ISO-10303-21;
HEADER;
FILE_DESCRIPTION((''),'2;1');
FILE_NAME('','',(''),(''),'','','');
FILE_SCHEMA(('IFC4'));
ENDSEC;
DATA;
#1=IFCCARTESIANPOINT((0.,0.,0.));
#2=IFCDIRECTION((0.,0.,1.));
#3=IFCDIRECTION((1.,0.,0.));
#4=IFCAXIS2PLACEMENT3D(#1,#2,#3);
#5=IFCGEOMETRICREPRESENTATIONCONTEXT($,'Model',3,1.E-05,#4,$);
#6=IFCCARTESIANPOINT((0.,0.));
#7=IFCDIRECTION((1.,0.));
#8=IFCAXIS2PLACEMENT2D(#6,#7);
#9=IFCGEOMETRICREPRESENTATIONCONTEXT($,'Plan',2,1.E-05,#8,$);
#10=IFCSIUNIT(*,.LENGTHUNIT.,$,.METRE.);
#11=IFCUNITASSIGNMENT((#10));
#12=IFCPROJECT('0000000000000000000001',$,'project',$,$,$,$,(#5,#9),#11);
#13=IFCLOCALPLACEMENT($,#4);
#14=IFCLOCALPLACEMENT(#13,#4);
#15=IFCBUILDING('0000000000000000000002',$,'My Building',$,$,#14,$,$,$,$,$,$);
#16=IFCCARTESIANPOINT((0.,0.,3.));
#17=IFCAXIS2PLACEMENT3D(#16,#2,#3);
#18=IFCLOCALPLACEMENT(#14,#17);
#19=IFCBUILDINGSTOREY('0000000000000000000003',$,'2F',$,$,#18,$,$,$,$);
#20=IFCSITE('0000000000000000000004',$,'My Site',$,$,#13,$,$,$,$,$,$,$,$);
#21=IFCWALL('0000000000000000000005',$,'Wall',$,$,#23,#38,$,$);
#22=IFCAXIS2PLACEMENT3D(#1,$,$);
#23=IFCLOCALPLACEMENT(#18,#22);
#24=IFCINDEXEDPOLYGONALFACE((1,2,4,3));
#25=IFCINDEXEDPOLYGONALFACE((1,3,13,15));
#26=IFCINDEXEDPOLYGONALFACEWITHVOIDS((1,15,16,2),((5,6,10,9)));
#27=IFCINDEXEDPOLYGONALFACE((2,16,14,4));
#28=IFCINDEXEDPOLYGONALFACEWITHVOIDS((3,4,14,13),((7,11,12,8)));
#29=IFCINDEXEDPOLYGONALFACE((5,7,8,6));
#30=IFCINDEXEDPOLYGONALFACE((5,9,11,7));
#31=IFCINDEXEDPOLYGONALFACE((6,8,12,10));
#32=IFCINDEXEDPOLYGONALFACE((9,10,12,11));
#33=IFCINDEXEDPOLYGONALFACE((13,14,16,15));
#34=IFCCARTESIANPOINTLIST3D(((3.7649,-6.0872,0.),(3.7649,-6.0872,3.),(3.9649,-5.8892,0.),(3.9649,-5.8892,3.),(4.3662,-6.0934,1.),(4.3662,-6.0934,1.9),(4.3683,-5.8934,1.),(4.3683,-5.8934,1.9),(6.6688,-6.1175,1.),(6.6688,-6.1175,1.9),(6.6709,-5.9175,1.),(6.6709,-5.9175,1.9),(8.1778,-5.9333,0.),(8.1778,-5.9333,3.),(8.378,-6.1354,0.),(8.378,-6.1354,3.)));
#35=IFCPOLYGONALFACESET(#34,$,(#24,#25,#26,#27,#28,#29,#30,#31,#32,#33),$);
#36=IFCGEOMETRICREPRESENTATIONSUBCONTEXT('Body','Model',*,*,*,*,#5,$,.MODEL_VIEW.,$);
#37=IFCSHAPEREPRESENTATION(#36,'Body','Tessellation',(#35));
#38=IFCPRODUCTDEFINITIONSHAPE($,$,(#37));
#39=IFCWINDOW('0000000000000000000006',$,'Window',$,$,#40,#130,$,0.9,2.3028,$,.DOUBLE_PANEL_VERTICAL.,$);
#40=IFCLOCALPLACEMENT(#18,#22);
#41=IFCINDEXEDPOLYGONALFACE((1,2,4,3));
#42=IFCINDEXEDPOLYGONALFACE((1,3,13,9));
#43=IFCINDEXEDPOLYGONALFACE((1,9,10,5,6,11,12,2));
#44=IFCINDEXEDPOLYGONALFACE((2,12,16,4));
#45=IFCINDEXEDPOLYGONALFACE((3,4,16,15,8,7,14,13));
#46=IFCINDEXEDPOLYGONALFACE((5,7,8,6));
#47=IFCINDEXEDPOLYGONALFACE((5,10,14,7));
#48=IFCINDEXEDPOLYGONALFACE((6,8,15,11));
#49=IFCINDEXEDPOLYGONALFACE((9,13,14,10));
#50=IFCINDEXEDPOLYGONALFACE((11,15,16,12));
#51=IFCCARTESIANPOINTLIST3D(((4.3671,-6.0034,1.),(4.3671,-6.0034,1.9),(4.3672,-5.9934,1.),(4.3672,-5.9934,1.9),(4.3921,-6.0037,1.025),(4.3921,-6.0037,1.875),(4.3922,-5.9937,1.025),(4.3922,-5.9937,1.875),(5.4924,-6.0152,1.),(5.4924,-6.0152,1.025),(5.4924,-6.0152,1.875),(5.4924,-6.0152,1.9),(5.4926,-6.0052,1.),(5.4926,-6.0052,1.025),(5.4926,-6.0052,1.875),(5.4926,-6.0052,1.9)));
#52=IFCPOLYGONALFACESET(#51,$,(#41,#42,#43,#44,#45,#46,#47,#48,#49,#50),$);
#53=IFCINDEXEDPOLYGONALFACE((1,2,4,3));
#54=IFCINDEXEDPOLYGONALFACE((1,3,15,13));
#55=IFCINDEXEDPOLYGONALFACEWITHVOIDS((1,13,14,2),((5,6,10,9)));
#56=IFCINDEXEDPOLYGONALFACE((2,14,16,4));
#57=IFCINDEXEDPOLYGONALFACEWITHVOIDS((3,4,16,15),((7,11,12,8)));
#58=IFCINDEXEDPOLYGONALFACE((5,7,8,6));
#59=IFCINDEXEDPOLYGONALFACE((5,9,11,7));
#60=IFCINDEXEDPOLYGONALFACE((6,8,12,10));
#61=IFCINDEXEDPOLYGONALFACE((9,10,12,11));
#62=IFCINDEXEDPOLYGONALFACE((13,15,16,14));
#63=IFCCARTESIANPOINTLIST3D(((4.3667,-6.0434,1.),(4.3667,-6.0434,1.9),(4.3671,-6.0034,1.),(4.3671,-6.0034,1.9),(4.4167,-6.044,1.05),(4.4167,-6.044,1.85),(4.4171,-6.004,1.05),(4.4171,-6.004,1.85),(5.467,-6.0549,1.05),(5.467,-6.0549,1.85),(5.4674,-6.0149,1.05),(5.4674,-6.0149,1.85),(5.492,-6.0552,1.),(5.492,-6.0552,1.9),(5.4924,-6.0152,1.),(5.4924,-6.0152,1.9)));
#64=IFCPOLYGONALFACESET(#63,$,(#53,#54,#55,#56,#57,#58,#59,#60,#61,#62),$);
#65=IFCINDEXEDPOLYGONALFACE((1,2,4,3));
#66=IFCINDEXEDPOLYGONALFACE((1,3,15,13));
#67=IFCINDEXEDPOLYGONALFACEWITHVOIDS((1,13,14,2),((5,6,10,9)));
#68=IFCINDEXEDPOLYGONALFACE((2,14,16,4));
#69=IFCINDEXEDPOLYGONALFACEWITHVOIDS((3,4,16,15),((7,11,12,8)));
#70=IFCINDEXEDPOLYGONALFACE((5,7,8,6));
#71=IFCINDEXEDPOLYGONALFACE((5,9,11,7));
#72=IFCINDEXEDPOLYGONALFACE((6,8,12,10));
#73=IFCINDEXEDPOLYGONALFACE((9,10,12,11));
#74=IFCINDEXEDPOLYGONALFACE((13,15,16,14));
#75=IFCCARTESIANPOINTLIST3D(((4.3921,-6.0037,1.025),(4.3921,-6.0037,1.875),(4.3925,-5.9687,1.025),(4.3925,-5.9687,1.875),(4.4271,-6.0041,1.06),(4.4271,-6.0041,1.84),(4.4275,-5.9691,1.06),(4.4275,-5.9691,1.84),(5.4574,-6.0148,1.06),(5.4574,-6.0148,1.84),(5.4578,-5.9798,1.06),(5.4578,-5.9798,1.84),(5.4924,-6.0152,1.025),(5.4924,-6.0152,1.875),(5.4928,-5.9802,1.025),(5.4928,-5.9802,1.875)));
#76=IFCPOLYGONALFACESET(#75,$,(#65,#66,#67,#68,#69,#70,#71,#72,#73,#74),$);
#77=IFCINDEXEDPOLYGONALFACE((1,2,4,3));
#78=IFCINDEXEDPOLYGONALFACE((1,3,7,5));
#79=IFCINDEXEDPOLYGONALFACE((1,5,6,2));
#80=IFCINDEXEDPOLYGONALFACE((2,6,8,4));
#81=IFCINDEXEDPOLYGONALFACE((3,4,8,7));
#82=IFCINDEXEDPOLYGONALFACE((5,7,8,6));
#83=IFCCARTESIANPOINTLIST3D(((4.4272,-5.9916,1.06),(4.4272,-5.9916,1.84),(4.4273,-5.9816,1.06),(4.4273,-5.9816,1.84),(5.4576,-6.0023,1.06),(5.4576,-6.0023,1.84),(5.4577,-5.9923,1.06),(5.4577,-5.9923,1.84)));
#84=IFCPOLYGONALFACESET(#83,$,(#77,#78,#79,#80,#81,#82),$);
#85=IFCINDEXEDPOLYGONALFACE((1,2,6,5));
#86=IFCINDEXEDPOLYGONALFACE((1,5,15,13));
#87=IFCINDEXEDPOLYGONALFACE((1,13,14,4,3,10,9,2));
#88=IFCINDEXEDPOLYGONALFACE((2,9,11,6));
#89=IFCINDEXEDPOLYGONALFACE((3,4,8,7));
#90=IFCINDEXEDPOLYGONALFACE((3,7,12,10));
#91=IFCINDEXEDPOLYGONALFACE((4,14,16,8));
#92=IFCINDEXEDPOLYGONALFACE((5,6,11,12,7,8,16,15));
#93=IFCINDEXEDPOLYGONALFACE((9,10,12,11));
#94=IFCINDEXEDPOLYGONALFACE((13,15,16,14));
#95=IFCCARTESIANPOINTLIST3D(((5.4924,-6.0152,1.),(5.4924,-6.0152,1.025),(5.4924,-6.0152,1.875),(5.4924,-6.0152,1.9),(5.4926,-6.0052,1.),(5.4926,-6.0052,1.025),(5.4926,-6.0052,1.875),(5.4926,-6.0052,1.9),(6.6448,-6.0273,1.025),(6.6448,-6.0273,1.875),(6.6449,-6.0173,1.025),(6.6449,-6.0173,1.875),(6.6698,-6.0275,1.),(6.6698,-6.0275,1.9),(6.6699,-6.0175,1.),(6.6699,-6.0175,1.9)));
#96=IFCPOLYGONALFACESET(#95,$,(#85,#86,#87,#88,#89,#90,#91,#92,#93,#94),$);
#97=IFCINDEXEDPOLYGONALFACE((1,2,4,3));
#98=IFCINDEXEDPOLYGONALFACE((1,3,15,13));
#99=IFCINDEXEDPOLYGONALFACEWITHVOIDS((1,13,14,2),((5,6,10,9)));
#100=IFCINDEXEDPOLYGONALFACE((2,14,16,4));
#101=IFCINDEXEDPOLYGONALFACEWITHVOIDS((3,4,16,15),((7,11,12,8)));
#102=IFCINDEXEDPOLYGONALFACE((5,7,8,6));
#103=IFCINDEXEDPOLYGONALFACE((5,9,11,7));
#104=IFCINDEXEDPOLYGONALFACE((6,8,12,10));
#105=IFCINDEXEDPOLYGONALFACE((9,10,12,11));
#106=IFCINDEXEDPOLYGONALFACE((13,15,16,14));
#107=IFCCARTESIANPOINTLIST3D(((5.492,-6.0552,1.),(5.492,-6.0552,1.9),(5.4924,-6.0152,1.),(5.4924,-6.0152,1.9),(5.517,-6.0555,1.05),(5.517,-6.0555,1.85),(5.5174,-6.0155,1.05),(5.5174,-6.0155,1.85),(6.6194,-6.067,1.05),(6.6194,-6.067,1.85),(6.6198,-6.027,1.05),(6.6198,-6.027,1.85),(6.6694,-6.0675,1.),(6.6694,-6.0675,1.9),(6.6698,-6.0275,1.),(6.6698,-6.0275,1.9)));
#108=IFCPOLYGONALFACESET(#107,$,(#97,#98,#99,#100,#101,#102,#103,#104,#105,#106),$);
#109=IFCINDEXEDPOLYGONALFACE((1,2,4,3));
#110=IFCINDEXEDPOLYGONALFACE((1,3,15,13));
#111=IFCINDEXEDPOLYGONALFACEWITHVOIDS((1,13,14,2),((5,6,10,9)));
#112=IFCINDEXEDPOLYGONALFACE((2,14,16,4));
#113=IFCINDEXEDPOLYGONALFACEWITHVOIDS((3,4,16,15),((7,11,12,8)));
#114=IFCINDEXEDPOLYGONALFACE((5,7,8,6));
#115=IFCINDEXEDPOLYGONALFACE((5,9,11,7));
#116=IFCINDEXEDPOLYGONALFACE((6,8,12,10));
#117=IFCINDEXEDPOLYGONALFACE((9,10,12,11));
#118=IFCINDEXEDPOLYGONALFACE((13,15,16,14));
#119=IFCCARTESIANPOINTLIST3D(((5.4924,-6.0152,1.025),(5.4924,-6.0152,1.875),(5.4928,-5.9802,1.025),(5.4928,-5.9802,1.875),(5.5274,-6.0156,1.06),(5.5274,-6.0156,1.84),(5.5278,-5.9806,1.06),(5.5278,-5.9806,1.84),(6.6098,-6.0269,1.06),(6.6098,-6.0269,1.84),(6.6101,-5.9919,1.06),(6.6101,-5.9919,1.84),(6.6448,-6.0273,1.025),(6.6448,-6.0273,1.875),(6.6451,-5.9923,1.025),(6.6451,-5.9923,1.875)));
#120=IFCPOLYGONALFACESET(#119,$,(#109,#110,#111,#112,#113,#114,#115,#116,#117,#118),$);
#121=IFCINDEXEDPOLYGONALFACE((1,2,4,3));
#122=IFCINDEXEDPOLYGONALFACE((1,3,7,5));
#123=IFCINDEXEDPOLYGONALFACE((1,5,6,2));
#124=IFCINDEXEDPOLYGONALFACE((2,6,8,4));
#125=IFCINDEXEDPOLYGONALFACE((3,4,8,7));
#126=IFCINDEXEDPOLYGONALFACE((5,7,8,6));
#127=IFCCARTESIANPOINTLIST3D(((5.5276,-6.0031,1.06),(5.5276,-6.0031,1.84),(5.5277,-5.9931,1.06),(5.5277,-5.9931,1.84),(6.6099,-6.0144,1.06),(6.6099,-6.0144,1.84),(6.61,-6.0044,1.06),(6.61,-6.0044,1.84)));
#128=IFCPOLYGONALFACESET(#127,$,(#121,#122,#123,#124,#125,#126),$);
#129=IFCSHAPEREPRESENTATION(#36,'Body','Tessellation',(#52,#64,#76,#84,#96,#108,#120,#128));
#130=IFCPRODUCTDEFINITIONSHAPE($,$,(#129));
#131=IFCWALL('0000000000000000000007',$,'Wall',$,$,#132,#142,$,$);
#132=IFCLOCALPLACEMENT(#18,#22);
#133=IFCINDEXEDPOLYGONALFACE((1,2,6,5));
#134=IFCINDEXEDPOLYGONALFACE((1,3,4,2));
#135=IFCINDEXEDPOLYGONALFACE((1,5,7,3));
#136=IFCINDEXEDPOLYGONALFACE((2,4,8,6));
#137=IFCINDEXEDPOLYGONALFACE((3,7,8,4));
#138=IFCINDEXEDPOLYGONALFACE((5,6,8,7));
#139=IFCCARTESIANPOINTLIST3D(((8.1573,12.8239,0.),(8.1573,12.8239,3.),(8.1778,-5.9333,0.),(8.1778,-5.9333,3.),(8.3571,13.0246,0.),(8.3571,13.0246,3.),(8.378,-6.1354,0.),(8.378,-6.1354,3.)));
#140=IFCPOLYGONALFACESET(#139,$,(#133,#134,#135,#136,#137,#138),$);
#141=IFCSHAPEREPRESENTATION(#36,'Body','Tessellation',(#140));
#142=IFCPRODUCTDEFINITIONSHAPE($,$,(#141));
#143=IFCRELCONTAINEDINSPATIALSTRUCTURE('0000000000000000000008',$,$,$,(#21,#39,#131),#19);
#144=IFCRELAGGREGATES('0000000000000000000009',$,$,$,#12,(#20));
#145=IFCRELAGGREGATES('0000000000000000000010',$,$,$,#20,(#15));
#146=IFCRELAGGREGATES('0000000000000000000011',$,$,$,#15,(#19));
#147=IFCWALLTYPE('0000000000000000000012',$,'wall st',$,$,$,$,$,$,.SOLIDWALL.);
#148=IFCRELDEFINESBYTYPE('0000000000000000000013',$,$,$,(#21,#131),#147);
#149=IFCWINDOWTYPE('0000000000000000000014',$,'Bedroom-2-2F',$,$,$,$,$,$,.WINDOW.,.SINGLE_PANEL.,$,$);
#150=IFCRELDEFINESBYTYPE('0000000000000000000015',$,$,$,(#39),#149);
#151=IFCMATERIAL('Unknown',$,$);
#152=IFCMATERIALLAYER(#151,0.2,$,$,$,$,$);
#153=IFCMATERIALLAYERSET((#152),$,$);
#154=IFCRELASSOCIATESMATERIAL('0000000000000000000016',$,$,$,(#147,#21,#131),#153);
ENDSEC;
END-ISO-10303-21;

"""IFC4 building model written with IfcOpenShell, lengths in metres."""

from ifc_helpers import new_model, entity, si_unit, frame, origin_with_axes, origin_2d_with_axis, place, context, subcontext, project, spatial, line, indexed_curve, outline, extrude, shape, source, transform, mapped, material, layer, layer_set, layer_usage, type_object, type_shapes, element, fill, save


model = new_model("IFC4")

# Units and contexts
model_context = context("Model", 3, precision=1e-05, world=origin_with_axes())
plan_context = context("Plan", 2, precision=1e-05, world=origin_2d_with_axis())
body_context_1 = subcontext(model_context, "Body", "Model", "MODEL_VIEW")
body_context_2 = subcontext(plan_context, "Body", "Plan", "PLAN_VIEW")
ifc_project = project(units=[si_unit("LENGTHUNIT", "METRE")], contexts=[model_context, plan_context])

# Site, building, storey
site_placement = place(None, origin_with_axes())
site = spatial("IfcSite", under=ifc_project, at=site_placement, Name="My Site")
building_placement = place(site_placement, origin_with_axes())
building = spatial("IfcBuilding", under=site, at=building_placement, Name="My Building")
storey_placement = place(building_placement, frame((0.0, 0.0, 3.0), z_axis=(0.0, 0.0, 1.0), x_axis=(1.0, 0.0, 0.0)))
storey = spatial("IfcBuildingStorey", under=building, at=storey_placement, Name="2F")

# Shared definitions
ifc_material = material(Name="Unknown")

# Shared definitions
ifc_layer_1 = layer(ifc_material, 0.2)
ifc_layer_set_1 = layer_set([ifc_layer_1])
wall_type_1 = type_object("IfcWallType", Name="wall st", PredefinedType="SOLIDWALL", material=ifc_layer_set_1)

# Wall, opening, window
ifc_layer_usage_1 = layer_usage(ifc_layer_set_1, "AXIS2", "POSITIVE", 0.0)
wall_1_placement = place(storey_placement, frame((3.7649, -6.0872, 0.0), z_axis=(0.0, 0.0, 1.0), x_axis=(0.999945, -0.010453, 0.0)))
wall_1 = element("IfcWall", 1, at=wall_1_placement, inside=storey, type_object=wall_type_1, material=ifc_layer_usage_1, Name="Wall", context=body_context_1, shape_type="SweptSolid", body=[
    extrude(outline(indexed_curve([(0.0, 0.0), (0.1979, 0.2), (4.4111, 0.2), (4.6134, 0.0)], segments=[line(1, 2, 3, 4, 1)])), origin_with_axes(), (0.0, 0.0, 1.0), 3.0),
])
shared_shape_1 = source(origin_with_axes(), body_context_1, "Body", "SweptSolid", [
    extrude(outline(indexed_curve([(0.0, 0.0), (2.3028, 0.0), (2.3028, 0.9), (0.0, 0.9)], segments=[line(1, 2, 3, 4, 1)])), frame((0.0, -0.6, 0.0), z_axis=(0.0, -1.0, 0.0), x_axis=(1.0, 0.0, 0.0)), (0.0, 0.0, -1.0), 1.2),
])
opening_1_placement = place(wall_1_placement, frame((0.6013, 0.0, 1.0), z_axis=(0.0, 0.0, 1.0), x_axis=(1.0, 0.0, 0.0)))
opening_1 = element("IfcOpeningElement", 2, at=opening_1_placement, cuts=wall_1, PredefinedType="OPENING", context=body_context_1, shape_type="MappedRepresentation", body=[
    mapped(shared_shape_1, transform((0.0, 0.0, 0.0), x_axis=(1.0, 0.0, 0.0), y_axis=(0.0, 1.0, 0.0), z_axis=(0.0, 0.0, 1.0), scale=1.0)),
])
window_type_1 = type_object("IfcWindowType", Name="Bedroom-2-2F", PartitioningType="SINGLE_PANEL", PredefinedType="WINDOW")
shared_shape_2 = source(origin_with_axes(), body_context_1, "Body", "SweptSolid", [
    extrude(outline(indexed_curve([(1.1254, 0.0), (0.0, 0.0), (0.0, 0.9), (1.1254, 0.9), (1.1254, 0.875), (0.025, 0.875), (0.025, 0.025), (1.1254, 0.025)], segments=[line(1, 2, 3, 4, 5, 6, 7, 8, 1)])), frame((0.0, 0.09, 0.0), z_axis=(0.0, -1.0, 0.0), x_axis=(1.0, 0.0, 0.0)), (0.0, 0.0, -1.0), 0.01),
    extrude(outline(indexed_curve([(0.0, 0.0), (1.1254, 0.0), (1.1254, 0.9), (0.0, 0.9)], segments=[line(1, 2, 3, 4, 1)]), holes=[indexed_curve([(0.05, 0.05), (1.1004, 0.05), (1.1004, 0.85), (0.05, 0.85)], segments=[line(1, 2, 3, 4, 1)])]), frame((0.0, 0.05, 0.0), z_axis=(0.0, -1.0, 0.0), x_axis=(1.0, 0.0, 0.0)), (0.0, 0.0, -1.0), 0.04),
    extrude(outline(indexed_curve([(0.0, 0.0), (1.1004, 0.0), (1.1004, 0.85), (0.0, 0.85)], segments=[line(1, 2, 3, 4, 1)]), holes=[indexed_curve([(0.035, 0.035), (1.0654, 0.035), (1.0654, 0.815), (0.035, 0.815)], segments=[line(1, 2, 3, 4, 1)])]), frame((0.025, 0.09, 0.025), z_axis=(0.0, -1.0, 0.0), x_axis=(1.0, 0.0, 0.0)), (0.0, 0.0, -1.0), 0.035),
    extrude(outline(indexed_curve([(0.035, 0.035), (1.0654, 0.035), (1.0654, 0.815), (0.035, 0.815)], segments=[line(1, 2, 3, 4, 1)])), frame((0.025, 0.1025, 0.025), z_axis=(0.0, -1.0, 0.0), x_axis=(1.0, 0.0, 0.0)), (0.0, 0.0, -1.0), 0.01),
    extrude(outline(indexed_curve([(0.0, 0.9), (1.1774, 0.9), (1.1774, 0.0), (0.0, 0.0), (0.0, 0.025), (1.1524, 0.025), (1.1524, 0.875), (0.0, 0.875)], segments=[line(1, 2, 3, 4, 5, 6, 7, 8, 1)])), frame((1.1254, 0.09, 0.0), z_axis=(0.0, -1.0, 0.0), x_axis=(1.0, 0.0, 0.0)), (0.0, 0.0, -1.0), 0.01),
    extrude(outline(indexed_curve([(0.0, 0.0), (1.1774, 0.0), (1.1774, 0.9), (0.0, 0.9)], segments=[line(1, 2, 3, 4, 1)]), holes=[indexed_curve([(0.025, 0.05), (1.1274, 0.05), (1.1274, 0.85), (0.025, 0.85)], segments=[line(1, 2, 3, 4, 1)])]), frame((1.1254, 0.05, 0.0), z_axis=(0.0, -1.0, 0.0), x_axis=(1.0, 0.0, 0.0)), (0.0, 0.0, -1.0), 0.04),
    extrude(outline(indexed_curve([(0.0, 0.0), (1.1524, 0.0), (1.1524, 0.85), (0.0, 0.85)], segments=[line(1, 2, 3, 4, 1)]), holes=[indexed_curve([(0.035, 0.035), (1.1174, 0.035), (1.1174, 0.815), (0.035, 0.815)], segments=[line(1, 2, 3, 4, 1)])]), frame((1.1254, 0.09, 0.025), z_axis=(0.0, -1.0, 0.0), x_axis=(1.0, 0.0, 0.0)), (0.0, 0.0, -1.0), 0.035),
    extrude(outline(indexed_curve([(0.035, 0.035), (1.1174, 0.035), (1.1174, 0.815), (0.035, 0.815)], segments=[line(1, 2, 3, 4, 1)])), frame((1.1254, 0.1025, 0.025), z_axis=(0.0, -1.0, 0.0), x_axis=(1.0, 0.0, 0.0)), (0.0, 0.0, -1.0), 0.01),
])
shared_shape_3 = source(origin_with_axes(), body_context_2, "Body", "Curve2D", [
    entity("IfcIndexedPolyCurve", entity("IfcCartesianPointList2D", [[0.05, 0.05], [1.1004, 0.05]])),
    entity("IfcIndexedPolyCurve", entity("IfcCartesianPointList2D", [[0.0, 0.1], [0.025, 0.1], [0.025, 0.09], [0.05, 0.09], [0.05, 0.05], [0.0, 0.05]]), [entity("IfcLineIndex", [1, 2, 3, 4, 5, 6, 1])]),
    entity("IfcIndexedPolyCurve", entity("IfcCartesianPointList2D", [[1.1254, 0.1], [1.1254, 0.1], [1.1254, 0.09], [1.1004, 0.09], [1.1004, 0.05], [1.1254, 0.05]])),
    entity("IfcIndexedPolyCurve", entity("IfcCartesianPointList2D", [[0.025, 0.09], [0.06, 0.09], [0.06, 0.125], [0.025, 0.125]]), [entity("IfcLineIndex", [1, 2, 3, 4, 1])]),
    entity("IfcIndexedPolyCurve", entity("IfcCartesianPointList2D", [[1.1254, 0.09], [1.0904, 0.09], [1.0904, 0.125], [1.1254, 0.125]]), [entity("IfcLineIndex", [1, 2, 3, 4, 1])]),
    entity("IfcIndexedPolyCurve", entity("IfcCartesianPointList2D", [[0.06, 0.09], [1.0904, 0.09]])),
    entity("IfcIndexedPolyCurve", entity("IfcCartesianPointList2D", [[0.06, 0.125], [1.0904, 0.125]])),
    entity("IfcIndexedPolyCurve", entity("IfcCartesianPointList2D", [[0.06, 0.1075], [1.0904, 0.1075]])),
    entity("IfcIndexedPolyCurve", entity("IfcCartesianPointList2D", [[1.1504, 0.05], [2.2528, 0.05]])),
    entity("IfcIndexedPolyCurve", entity("IfcCartesianPointList2D", [[1.1254, 0.1], [1.1254, 0.1], [1.1254, 0.09], [1.1504, 0.09], [1.1504, 0.05], [1.1254, 0.05]])),
    entity("IfcIndexedPolyCurve", entity("IfcCartesianPointList2D", [[2.3028, 0.1], [2.2778, 0.1], [2.2778, 0.09], [2.2528, 0.09], [2.2528, 0.05], [2.3028, 0.05]]), [entity("IfcLineIndex", [1, 2, 3, 4, 5, 6, 1])]),
    entity("IfcIndexedPolyCurve", entity("IfcCartesianPointList2D", [[1.1254, 0.09], [1.1604, 0.09], [1.1604, 0.125], [1.1254, 0.125]]), [entity("IfcLineIndex", [1, 2, 3, 4, 1])]),
    entity("IfcIndexedPolyCurve", entity("IfcCartesianPointList2D", [[2.2778, 0.09], [2.2428, 0.09], [2.2428, 0.125], [2.2778, 0.125]]), [entity("IfcLineIndex", [1, 2, 3, 4, 1])]),
    entity("IfcIndexedPolyCurve", entity("IfcCartesianPointList2D", [[1.1604, 0.09], [2.2428, 0.09]])),
    entity("IfcIndexedPolyCurve", entity("IfcCartesianPointList2D", [[1.1604, 0.125], [2.2428, 0.125]])),
    entity("IfcIndexedPolyCurve", entity("IfcCartesianPointList2D", [[1.1604, 0.1075], [2.2428, 0.1075]])),
])
type_shapes(window_type_1, [shared_shape_2, shared_shape_3])
window_1_placement = place(opening_1_placement, frame((0.0, 0.0, 0.0), z_axis=(0.0, 0.0, 1.0), x_axis=(1.0, 0.0, 0.0)))
window_1 = element("IfcWindow", 3, at=window_1_placement, inside=storey, type_object=window_type_1, Name="Window", OverallHeight=0.9, OverallWidth=2.3028, PartitioningType="DOUBLE_PANEL_VERTICAL", shapes=[
    shape(body_context_1, "Body", "MappedRepresentation", [mapped(shared_shape_2, transform((0.0, 0.0, 0.0), x_axis=(1.0, 0.0, 0.0), y_axis=(0.0, 1.0, 0.0), z_axis=(0.0, 0.0, 1.0), scale=1.0))]),
    shape(body_context_2, "Body", "MappedRepresentation", [mapped(shared_shape_3, transform((0.0, 0.0, 0.0), x_axis=(1.0, 0.0, 0.0), y_axis=(0.0, 1.0, 0.0), z_axis=(0.0, 0.0, 1.0), scale=1.0))]),
])
fill(opening_1, window_1)

# Wall
ifc_layer_usage_2 = layer_usage(ifc_layer_set_1, "AXIS2", "POSITIVE", 0.0)
wall_2_placement = place(storey_placement, frame((8.378, -6.1354, 0.0), z_axis=(0.0, 0.0, 1.0), x_axis=(-0.001091, 0.999999, 0.0)))
element("IfcWall", 4, at=wall_2_placement, inside=storey, type_object=wall_type_1, material=ifc_layer_usage_2, Name="Wall", context=body_context_1, shape_type="SweptSolid", body=[
    extrude(outline(indexed_curve([(0.0, 0.0), (0.2023, 0.2), (18.9595, 0.2), (19.1599, 0.0)], segments=[line(1, 2, 3, 4, 1)])), origin_with_axes(), (0.0, 0.0, 1.0), 3.0),
])

save(model, "model.ifc")
